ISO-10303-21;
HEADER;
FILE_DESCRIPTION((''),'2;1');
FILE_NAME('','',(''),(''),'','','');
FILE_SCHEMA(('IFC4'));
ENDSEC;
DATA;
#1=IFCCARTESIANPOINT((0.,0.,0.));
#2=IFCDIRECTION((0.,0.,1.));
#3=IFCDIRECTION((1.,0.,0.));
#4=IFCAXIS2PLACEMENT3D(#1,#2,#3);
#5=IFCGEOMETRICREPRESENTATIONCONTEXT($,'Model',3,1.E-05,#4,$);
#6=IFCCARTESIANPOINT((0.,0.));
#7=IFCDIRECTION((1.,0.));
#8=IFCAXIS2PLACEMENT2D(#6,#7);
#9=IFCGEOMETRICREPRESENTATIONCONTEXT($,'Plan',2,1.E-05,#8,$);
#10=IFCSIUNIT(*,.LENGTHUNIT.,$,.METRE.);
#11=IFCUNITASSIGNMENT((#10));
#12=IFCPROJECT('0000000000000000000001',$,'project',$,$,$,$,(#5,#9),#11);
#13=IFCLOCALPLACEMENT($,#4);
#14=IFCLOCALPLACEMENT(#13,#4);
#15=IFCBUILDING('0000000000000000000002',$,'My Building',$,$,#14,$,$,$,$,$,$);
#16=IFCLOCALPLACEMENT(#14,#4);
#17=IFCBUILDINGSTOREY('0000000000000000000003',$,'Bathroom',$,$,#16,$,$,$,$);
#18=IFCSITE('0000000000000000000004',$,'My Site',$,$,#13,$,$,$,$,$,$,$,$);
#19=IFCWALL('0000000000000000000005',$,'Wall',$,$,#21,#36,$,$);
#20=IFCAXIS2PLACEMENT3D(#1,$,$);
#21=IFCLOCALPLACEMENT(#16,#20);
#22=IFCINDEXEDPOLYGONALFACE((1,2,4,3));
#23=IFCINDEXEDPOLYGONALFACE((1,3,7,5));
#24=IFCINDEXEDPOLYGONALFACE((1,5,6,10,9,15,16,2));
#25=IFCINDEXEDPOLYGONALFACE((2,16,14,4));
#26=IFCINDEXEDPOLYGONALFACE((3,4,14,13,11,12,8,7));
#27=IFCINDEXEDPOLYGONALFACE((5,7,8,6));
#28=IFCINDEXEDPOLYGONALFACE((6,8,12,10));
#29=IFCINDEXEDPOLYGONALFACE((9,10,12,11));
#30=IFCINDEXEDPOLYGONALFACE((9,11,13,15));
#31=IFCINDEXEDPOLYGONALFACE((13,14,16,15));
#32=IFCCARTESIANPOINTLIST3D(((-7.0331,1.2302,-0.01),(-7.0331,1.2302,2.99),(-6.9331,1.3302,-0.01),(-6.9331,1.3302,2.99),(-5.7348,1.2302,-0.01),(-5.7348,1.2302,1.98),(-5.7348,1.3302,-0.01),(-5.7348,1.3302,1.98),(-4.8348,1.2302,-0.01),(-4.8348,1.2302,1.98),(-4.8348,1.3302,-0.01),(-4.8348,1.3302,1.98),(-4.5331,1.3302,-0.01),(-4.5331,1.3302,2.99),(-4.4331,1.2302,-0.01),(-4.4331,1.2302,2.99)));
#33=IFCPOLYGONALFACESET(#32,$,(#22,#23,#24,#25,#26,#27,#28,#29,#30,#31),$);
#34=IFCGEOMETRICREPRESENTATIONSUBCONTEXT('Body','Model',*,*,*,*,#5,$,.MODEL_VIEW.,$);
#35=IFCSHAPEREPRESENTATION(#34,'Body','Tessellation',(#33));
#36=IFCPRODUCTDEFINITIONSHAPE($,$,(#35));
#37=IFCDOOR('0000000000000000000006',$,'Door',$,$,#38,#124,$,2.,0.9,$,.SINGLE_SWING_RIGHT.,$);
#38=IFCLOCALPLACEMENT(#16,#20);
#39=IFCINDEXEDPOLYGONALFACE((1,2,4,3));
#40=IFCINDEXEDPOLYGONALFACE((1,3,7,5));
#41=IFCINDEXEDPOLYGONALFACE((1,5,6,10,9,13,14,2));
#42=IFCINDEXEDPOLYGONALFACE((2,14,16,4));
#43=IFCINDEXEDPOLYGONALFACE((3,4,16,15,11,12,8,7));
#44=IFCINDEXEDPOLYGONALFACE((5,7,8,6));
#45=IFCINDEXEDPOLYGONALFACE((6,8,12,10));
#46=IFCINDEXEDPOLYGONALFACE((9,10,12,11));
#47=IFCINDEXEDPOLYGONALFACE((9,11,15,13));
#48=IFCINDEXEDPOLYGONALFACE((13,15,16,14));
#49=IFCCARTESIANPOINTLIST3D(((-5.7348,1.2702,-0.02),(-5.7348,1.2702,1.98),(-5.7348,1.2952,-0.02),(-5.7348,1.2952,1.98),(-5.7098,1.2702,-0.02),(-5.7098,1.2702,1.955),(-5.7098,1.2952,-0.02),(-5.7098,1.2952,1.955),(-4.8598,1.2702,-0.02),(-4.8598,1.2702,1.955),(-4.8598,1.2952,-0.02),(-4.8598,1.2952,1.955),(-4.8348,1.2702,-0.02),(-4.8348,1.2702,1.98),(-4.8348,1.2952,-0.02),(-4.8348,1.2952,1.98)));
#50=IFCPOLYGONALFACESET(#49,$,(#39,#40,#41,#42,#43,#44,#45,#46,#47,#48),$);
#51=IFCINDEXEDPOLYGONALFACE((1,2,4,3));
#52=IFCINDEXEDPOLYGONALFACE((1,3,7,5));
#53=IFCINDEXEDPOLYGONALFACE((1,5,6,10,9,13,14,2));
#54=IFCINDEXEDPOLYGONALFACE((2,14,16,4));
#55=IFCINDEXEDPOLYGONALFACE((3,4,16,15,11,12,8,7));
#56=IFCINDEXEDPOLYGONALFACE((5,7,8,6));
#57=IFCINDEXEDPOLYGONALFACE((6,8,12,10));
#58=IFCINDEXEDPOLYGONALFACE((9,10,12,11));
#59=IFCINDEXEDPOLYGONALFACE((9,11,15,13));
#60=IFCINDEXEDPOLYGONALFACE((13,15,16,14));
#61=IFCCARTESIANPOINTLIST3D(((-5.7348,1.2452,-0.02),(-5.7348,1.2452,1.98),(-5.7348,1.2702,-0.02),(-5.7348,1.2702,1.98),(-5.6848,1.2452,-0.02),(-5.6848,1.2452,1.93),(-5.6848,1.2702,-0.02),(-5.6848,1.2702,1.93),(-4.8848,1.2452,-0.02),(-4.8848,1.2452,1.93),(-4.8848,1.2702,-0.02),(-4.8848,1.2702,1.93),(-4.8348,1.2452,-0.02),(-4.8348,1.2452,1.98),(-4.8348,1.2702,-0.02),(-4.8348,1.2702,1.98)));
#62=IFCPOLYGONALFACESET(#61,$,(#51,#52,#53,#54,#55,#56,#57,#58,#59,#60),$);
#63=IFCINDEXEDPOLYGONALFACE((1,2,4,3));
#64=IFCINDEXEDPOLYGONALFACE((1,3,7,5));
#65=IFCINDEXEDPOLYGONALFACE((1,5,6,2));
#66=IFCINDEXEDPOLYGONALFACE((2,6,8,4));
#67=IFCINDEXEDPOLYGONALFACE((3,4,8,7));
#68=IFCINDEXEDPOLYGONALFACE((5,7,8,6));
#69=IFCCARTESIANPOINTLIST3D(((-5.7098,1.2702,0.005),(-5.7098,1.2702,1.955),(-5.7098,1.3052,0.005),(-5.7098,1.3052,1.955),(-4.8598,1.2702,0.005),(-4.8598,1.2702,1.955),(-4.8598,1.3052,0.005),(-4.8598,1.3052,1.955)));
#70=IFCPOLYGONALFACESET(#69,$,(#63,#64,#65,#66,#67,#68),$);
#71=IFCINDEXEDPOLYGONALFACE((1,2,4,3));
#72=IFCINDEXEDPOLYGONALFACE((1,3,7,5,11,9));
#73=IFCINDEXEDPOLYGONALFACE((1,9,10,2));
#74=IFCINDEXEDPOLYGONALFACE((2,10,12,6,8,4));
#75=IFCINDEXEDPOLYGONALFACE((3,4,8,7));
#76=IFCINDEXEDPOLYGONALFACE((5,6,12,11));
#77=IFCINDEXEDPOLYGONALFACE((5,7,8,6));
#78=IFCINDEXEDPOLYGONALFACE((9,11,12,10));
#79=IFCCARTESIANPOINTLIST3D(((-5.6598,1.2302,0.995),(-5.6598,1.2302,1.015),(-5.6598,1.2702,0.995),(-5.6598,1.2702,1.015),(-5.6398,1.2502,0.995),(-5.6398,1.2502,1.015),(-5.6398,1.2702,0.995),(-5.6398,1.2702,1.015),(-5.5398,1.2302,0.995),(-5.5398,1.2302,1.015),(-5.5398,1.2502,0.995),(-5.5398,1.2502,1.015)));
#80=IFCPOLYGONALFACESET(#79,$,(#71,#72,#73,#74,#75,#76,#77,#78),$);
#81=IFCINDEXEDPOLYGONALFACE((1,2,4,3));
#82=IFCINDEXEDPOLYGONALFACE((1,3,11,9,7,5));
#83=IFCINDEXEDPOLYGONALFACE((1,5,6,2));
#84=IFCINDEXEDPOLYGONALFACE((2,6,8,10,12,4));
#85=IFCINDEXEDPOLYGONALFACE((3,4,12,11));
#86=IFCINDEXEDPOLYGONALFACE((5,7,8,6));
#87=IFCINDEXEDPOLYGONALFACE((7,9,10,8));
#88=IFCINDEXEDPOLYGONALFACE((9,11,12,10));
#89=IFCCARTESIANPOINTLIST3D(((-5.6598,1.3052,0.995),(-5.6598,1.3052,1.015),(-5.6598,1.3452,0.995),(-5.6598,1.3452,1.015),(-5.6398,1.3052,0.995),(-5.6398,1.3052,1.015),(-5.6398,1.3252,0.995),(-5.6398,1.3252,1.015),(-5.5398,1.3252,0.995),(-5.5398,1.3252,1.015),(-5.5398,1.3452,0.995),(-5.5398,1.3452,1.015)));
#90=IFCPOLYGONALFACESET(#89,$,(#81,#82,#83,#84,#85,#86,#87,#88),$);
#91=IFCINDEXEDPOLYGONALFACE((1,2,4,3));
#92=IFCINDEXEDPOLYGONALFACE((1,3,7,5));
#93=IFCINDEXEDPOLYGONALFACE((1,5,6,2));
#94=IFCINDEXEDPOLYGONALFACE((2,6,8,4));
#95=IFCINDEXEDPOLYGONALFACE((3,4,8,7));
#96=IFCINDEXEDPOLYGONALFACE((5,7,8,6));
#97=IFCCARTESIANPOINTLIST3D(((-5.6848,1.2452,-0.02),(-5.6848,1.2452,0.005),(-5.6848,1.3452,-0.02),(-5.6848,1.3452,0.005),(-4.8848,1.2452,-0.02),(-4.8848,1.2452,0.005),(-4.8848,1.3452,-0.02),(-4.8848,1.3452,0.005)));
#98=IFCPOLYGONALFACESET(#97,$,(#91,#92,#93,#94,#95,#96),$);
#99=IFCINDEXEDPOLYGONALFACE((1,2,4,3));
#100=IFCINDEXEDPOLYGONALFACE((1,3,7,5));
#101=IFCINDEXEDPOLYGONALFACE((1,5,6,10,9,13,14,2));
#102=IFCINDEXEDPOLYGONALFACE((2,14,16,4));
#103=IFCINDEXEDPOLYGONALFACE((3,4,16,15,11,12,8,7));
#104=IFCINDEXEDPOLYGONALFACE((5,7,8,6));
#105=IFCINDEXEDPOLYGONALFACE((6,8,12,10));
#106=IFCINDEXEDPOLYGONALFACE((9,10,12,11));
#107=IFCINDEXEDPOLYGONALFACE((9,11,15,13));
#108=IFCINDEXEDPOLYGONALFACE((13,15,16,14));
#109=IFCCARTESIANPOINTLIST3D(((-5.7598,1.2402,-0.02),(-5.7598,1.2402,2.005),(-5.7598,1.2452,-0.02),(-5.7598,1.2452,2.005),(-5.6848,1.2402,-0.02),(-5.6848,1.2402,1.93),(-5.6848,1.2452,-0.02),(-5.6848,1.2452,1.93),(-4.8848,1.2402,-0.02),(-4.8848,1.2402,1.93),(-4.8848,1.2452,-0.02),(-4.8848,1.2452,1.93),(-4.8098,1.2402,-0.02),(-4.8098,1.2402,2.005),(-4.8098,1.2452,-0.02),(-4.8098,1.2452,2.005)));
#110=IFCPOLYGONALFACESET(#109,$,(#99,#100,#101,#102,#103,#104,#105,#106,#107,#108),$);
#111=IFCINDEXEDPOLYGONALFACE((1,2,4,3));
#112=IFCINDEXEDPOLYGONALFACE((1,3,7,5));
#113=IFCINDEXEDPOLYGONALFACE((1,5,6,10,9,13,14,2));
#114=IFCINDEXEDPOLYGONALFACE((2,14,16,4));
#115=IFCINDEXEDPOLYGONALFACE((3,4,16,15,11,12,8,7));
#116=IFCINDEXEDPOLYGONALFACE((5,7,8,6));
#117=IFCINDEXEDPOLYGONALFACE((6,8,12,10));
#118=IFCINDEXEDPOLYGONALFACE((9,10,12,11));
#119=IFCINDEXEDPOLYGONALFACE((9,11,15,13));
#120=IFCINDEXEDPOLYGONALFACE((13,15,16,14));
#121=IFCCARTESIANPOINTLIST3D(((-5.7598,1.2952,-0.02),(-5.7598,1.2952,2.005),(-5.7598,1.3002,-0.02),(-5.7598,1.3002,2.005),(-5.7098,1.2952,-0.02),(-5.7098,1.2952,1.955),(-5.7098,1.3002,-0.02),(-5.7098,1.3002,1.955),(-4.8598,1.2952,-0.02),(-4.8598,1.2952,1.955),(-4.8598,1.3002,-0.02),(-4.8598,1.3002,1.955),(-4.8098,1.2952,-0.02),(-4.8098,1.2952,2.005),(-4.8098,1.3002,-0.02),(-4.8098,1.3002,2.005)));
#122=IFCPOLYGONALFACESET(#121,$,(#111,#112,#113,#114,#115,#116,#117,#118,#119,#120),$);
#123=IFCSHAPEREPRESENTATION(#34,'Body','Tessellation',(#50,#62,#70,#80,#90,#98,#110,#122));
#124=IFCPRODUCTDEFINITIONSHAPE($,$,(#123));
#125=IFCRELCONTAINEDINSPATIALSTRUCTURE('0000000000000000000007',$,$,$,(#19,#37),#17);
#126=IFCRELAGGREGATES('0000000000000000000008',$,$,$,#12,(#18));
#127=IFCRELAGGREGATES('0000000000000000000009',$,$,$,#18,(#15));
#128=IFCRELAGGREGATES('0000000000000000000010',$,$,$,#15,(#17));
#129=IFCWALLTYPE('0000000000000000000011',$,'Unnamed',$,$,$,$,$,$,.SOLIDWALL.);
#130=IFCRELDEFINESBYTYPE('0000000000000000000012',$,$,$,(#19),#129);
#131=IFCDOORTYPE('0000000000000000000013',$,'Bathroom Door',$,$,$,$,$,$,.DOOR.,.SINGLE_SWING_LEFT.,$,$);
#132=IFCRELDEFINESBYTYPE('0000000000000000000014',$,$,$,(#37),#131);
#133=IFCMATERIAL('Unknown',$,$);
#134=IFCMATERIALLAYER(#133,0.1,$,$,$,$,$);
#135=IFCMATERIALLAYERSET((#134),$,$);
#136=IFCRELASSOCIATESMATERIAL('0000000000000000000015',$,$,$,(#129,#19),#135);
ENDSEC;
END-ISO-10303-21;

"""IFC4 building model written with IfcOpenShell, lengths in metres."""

from ifc_helpers import new_model, entity, si_unit, frame, origin_with_axes, origin_2d_with_axis, place, context, subcontext, project, spatial, line, indexed_curve, outline, extrude, shape, source, transform, mapped, material, layer, layer_set, layer_usage, type_object, type_shapes, element, fill, save


model = new_model("IFC4")

# Units and contexts
model_context = context("Model", 3, precision=1e-05, world=origin_with_axes())
plan_context = context("Plan", 2, precision=1e-05, world=origin_2d_with_axis())
body_context_1 = subcontext(model_context, "Body", "Model", "MODEL_VIEW")
body_context_2 = subcontext(plan_context, "Body", "Plan", "PLAN_VIEW")
ifc_project = project(units=[si_unit("LENGTHUNIT", "METRE")], contexts=[model_context, plan_context])

# Site, building, storey
site_placement = place(None, origin_with_axes())
site = spatial("IfcSite", under=ifc_project, at=site_placement, Name="My Site")
building_placement = place(site_placement, origin_with_axes())
building = spatial("IfcBuilding", under=site, at=building_placement, Name="My Building")
storey_placement = place(building_placement, origin_with_axes())
storey = spatial("IfcBuildingStorey", under=building, at=storey_placement, Name="Bathroom")

# Shared definitions
ifc_material = material(Name="Unknown")

# Shared definitions
ifc_layer_1 = layer(ifc_material, 0.1)
ifc_layer_set_1 = layer_set([ifc_layer_1])
wall_type = type_object("IfcWallType", Name="Unnamed", PredefinedType="SOLIDWALL", material=ifc_layer_set_1)

# Shared definitions
shared_shape_1 = source(origin_with_axes(), body_context_1, "Body", "SweptSolid", [
    extrude(outline(indexed_curve([(0.0, 0.0), (0.9, 0.0), (0.9, 2.0), (0.0, 2.0)], segments=[line(1, 2, 3, 4, 1)])), frame((0.0, -0.6, 0.0), z_axis=(0.0, -1.0, 0.0), x_axis=(1.0, 0.0, 0.0)), (0.0, 0.0, -1.0), 1.2),
])
door_type = type_object("IfcDoorType", Name="Bathroom Door", OperationType="SINGLE_SWING_LEFT", PredefinedType="DOOR")
shared_shape_2 = source(origin_with_axes(), body_context_1, "Body", "SweptSolid", [
    extrude(outline(indexed_curve([(0.0, 0.0), (0.0, 2.0), (0.9, 2.0), (0.9, 0.0), (0.875, 0.0), (0.875, 1.975), (0.025, 1.975), (0.025, 0.0)], segments=[line(1, 2, 3, 4, 5, 6, 7, 8, 1)])), frame((0.0, 0.025, 0.0), z_axis=(0.0, -1.0, 0.0), x_axis=(1.0, 0.0, 0.0)), (0.0, 0.0, -1.0), 0.025),
    extrude(outline(indexed_curve([(0.0, 0.0), (0.0, 2.0), (0.9, 2.0), (0.9, 0.0), (0.85, 0.0), (0.85, 1.95), (0.05, 1.95), (0.05, 0.0)], segments=[line(1, 2, 3, 4, 5, 6, 7, 8, 1)])), frame((0.0, 0.0, 0.0), z_axis=(0.0, -1.0, 0.0), x_axis=(1.0, 0.0, 0.0)), (0.0, 0.0, -1.0), 0.025),
    extrude(outline(indexed_curve([(0.0, 0.0), (0.85, 0.0), (0.85, 0.035), (0.0, 0.035)], segments=[line(1, 2, 3, 4, 1)])), frame((0.025, 0.025, 0.025), z_axis=(0.0, 0.0, 1.0), x_axis=(1.0, 0.0, 0.0)), (0.0, 0.0, 1.0), 1.95),
    extrude(outline(indexed_curve([(0.0, 0.0), (0.0, -0.04), (0.12, -0.04), (0.12, -0.02), (0.02, -0.02), (0.02, 0.0)], segments=[line(1, 2, 3, 4, 5, 6, 1)])), frame((0.075, 0.025, 1.015), z_axis=(0.0, 0.0, 1.0), x_axis=(1.0, 0.0, 0.0)), (0.0, 0.0, 1.0), 0.02),
    extrude(outline(indexed_curve([(0.0, 0.0), (0.0, 0.04), (0.12, 0.04), (0.12, 0.02), (0.02, 0.02), (0.02, 0.0)], segments=[line(1, 2, 3, 4, 5, 6, 1)])), frame((0.075, 0.06, 1.015), z_axis=(0.0, 0.0, 1.0), x_axis=(1.0, 0.0, 0.0)), (0.0, 0.0, 1.0), 0.02),
    extrude(outline(indexed_curve([(0.0, 0.0), (0.8, 0.0), (0.8, 0.1), (0.0, 0.1)], segments=[line(1, 2, 3, 4, 1)])), frame((0.05, 0.0, 0.0), z_axis=(0.0, 0.0, 1.0), x_axis=(1.0, 0.0, 0.0)), (0.0, 0.0, 1.0), 0.025),
    extrude(outline(indexed_curve([(0.0, 0.0), (0.0, 2.025), (0.95, 2.025), (0.95, 0.0), (0.875, 0.0), (0.875, 1.95), (0.075, 1.95), (0.075, 0.0)], segments=[line(1, 2, 3, 4, 5, 6, 7, 8, 1)])), frame((-0.025, -0.005, 0.0), z_axis=(0.0, -1.0, 0.0), x_axis=(1.0, 0.0, 0.0)), (0.0, 0.0, -1.0), 0.005),
    extrude(outline(indexed_curve([(0.0, 0.0), (0.0, 2.025), (0.95, 2.025), (0.95, 0.0), (0.9, 0.0), (0.9, 1.975), (0.05, 1.975), (0.05, 0.0)], segments=[line(1, 2, 3, 4, 5, 6, 7, 8, 1)])), frame((-0.025, 0.05, 0.0), z_axis=(0.0, -1.0, 0.0), x_axis=(1.0, 0.0, 0.0)), (0.0, 0.0, -1.0), 0.005),
])
shared_shape_3 = source(origin_with_axes(), body_context_2, "Body", "Curve2D", [
    entity("IfcIndexedPolyCurve", entity("IfcCartesianPointList2D", [[0.0, 0.0], [0.0, 0.05], [0.025, 0.05], [0.025, 0.025], [0.05, 0.025], [0.05, 0.0]]), [entity("IfcLineIndex", [1, 2, 3, 4, 5, 6, 1])]),
    entity("IfcIndexedPolyCurve", entity("IfcCartesianPointList2D", [[0.9, 0.0], [0.9, 0.05], [0.875, 0.05], [0.875, 0.025], [0.85, 0.025], [0.85, 0.0]]), [entity("IfcLineIndex", [1, 2, 3, 4, 5, 6, 1])]),
    entity("IfcTrimmedCurve", entity("IfcEllipse", entity("IfcAxis2Placement2D", entity("IfcCartesianPoint", [0.84, 0.05]), entity("IfcDirection", [1.0, 0.0])), 0.815, 0.85), [entity("IfcCartesianPoint", [0.84, 0.9])], [entity("IfcCartesianPoint", [0.025, 0.05])], True, "CARTESIAN"),
    entity("IfcIndexedPolyCurve", entity("IfcCartesianPointList2D", [[0.875, 0.05], [0.84, 0.05], [0.84, 0.9], [0.875, 0.9]]), [entity("IfcLineIndex", [1, 2, 3, 4, 1])]),
])
type_shapes(door_type, [shared_shape_2, shared_shape_3])

# Wall, opening, door
ifc_layer_usage_1 = layer_usage(ifc_layer_set_1, "AXIS2", "POSITIVE", 0.0)
wall_1_placement = place(storey_placement, frame((-7.0331, 1.2302, -0.01), z_axis=(0.0, 0.0, 1.0), x_axis=(1.0, 0.0, 0.0)))
wall_1 = element("IfcWall", 1, at=wall_1_placement, inside=storey, type_object=wall_type, material=ifc_layer_usage_1, Name="Wall", context=body_context_1, shape_type="SweptSolid", body=[
    extrude(outline(indexed_curve([(0.0, 0.0), (0.1, 0.1), (2.5, 0.1), (2.6, 0.0)], segments=[line(1, 2, 3, 4, 1)])), origin_with_axes(), (0.0, 0.0, 1.0), 3.0),
])
opening_1_placement = place(wall_1_placement, frame((1.2984, 0.015, -0.01), z_axis=(0.0, 0.0, 1.0), x_axis=(1.0, 0.0, 0.0)))
opening_1 = element("IfcOpeningElement", 2, at=opening_1_placement, cuts=wall_1, PredefinedType="OPENING", context=body_context_1, shape_type="MappedRepresentation", body=[
    mapped(shared_shape_1, transform((0.0, 0.0, 0.0), x_axis=(1.0, 0.0, 0.0), y_axis=(0.0, 1.0, 0.0), z_axis=(0.0, 0.0, 1.0), scale=1.0)),
])
door_1_placement = place(opening_1_placement, frame((0.0, 0.0, 0.0), z_axis=(0.0, 0.0, 1.0), x_axis=(1.0, 0.0, 0.0)))
door_1 = element("IfcDoor", 3, at=door_1_placement, inside=storey, type_object=door_type, Name="Door", OperationType="SINGLE_SWING_RIGHT", OverallHeight=2.0, OverallWidth=0.9, shapes=[
    shape(body_context_1, "Body", "MappedRepresentation", [mapped(shared_shape_2, transform((0.0, 0.0, 0.0), x_axis=(1.0, 0.0, 0.0), y_axis=(0.0, 1.0, 0.0), z_axis=(0.0, 0.0, 1.0), scale=1.0))]),
    shape(body_context_2, "Body", "MappedRepresentation", [mapped(shared_shape_3, transform((0.0, 0.0, 0.0), x_axis=(1.0, 0.0, 0.0), y_axis=(0.0, 1.0, 0.0), z_axis=(0.0, 0.0, 1.0), scale=1.0))]),
])
fill(opening_1, door_1)

save(model, "model.ifc")
